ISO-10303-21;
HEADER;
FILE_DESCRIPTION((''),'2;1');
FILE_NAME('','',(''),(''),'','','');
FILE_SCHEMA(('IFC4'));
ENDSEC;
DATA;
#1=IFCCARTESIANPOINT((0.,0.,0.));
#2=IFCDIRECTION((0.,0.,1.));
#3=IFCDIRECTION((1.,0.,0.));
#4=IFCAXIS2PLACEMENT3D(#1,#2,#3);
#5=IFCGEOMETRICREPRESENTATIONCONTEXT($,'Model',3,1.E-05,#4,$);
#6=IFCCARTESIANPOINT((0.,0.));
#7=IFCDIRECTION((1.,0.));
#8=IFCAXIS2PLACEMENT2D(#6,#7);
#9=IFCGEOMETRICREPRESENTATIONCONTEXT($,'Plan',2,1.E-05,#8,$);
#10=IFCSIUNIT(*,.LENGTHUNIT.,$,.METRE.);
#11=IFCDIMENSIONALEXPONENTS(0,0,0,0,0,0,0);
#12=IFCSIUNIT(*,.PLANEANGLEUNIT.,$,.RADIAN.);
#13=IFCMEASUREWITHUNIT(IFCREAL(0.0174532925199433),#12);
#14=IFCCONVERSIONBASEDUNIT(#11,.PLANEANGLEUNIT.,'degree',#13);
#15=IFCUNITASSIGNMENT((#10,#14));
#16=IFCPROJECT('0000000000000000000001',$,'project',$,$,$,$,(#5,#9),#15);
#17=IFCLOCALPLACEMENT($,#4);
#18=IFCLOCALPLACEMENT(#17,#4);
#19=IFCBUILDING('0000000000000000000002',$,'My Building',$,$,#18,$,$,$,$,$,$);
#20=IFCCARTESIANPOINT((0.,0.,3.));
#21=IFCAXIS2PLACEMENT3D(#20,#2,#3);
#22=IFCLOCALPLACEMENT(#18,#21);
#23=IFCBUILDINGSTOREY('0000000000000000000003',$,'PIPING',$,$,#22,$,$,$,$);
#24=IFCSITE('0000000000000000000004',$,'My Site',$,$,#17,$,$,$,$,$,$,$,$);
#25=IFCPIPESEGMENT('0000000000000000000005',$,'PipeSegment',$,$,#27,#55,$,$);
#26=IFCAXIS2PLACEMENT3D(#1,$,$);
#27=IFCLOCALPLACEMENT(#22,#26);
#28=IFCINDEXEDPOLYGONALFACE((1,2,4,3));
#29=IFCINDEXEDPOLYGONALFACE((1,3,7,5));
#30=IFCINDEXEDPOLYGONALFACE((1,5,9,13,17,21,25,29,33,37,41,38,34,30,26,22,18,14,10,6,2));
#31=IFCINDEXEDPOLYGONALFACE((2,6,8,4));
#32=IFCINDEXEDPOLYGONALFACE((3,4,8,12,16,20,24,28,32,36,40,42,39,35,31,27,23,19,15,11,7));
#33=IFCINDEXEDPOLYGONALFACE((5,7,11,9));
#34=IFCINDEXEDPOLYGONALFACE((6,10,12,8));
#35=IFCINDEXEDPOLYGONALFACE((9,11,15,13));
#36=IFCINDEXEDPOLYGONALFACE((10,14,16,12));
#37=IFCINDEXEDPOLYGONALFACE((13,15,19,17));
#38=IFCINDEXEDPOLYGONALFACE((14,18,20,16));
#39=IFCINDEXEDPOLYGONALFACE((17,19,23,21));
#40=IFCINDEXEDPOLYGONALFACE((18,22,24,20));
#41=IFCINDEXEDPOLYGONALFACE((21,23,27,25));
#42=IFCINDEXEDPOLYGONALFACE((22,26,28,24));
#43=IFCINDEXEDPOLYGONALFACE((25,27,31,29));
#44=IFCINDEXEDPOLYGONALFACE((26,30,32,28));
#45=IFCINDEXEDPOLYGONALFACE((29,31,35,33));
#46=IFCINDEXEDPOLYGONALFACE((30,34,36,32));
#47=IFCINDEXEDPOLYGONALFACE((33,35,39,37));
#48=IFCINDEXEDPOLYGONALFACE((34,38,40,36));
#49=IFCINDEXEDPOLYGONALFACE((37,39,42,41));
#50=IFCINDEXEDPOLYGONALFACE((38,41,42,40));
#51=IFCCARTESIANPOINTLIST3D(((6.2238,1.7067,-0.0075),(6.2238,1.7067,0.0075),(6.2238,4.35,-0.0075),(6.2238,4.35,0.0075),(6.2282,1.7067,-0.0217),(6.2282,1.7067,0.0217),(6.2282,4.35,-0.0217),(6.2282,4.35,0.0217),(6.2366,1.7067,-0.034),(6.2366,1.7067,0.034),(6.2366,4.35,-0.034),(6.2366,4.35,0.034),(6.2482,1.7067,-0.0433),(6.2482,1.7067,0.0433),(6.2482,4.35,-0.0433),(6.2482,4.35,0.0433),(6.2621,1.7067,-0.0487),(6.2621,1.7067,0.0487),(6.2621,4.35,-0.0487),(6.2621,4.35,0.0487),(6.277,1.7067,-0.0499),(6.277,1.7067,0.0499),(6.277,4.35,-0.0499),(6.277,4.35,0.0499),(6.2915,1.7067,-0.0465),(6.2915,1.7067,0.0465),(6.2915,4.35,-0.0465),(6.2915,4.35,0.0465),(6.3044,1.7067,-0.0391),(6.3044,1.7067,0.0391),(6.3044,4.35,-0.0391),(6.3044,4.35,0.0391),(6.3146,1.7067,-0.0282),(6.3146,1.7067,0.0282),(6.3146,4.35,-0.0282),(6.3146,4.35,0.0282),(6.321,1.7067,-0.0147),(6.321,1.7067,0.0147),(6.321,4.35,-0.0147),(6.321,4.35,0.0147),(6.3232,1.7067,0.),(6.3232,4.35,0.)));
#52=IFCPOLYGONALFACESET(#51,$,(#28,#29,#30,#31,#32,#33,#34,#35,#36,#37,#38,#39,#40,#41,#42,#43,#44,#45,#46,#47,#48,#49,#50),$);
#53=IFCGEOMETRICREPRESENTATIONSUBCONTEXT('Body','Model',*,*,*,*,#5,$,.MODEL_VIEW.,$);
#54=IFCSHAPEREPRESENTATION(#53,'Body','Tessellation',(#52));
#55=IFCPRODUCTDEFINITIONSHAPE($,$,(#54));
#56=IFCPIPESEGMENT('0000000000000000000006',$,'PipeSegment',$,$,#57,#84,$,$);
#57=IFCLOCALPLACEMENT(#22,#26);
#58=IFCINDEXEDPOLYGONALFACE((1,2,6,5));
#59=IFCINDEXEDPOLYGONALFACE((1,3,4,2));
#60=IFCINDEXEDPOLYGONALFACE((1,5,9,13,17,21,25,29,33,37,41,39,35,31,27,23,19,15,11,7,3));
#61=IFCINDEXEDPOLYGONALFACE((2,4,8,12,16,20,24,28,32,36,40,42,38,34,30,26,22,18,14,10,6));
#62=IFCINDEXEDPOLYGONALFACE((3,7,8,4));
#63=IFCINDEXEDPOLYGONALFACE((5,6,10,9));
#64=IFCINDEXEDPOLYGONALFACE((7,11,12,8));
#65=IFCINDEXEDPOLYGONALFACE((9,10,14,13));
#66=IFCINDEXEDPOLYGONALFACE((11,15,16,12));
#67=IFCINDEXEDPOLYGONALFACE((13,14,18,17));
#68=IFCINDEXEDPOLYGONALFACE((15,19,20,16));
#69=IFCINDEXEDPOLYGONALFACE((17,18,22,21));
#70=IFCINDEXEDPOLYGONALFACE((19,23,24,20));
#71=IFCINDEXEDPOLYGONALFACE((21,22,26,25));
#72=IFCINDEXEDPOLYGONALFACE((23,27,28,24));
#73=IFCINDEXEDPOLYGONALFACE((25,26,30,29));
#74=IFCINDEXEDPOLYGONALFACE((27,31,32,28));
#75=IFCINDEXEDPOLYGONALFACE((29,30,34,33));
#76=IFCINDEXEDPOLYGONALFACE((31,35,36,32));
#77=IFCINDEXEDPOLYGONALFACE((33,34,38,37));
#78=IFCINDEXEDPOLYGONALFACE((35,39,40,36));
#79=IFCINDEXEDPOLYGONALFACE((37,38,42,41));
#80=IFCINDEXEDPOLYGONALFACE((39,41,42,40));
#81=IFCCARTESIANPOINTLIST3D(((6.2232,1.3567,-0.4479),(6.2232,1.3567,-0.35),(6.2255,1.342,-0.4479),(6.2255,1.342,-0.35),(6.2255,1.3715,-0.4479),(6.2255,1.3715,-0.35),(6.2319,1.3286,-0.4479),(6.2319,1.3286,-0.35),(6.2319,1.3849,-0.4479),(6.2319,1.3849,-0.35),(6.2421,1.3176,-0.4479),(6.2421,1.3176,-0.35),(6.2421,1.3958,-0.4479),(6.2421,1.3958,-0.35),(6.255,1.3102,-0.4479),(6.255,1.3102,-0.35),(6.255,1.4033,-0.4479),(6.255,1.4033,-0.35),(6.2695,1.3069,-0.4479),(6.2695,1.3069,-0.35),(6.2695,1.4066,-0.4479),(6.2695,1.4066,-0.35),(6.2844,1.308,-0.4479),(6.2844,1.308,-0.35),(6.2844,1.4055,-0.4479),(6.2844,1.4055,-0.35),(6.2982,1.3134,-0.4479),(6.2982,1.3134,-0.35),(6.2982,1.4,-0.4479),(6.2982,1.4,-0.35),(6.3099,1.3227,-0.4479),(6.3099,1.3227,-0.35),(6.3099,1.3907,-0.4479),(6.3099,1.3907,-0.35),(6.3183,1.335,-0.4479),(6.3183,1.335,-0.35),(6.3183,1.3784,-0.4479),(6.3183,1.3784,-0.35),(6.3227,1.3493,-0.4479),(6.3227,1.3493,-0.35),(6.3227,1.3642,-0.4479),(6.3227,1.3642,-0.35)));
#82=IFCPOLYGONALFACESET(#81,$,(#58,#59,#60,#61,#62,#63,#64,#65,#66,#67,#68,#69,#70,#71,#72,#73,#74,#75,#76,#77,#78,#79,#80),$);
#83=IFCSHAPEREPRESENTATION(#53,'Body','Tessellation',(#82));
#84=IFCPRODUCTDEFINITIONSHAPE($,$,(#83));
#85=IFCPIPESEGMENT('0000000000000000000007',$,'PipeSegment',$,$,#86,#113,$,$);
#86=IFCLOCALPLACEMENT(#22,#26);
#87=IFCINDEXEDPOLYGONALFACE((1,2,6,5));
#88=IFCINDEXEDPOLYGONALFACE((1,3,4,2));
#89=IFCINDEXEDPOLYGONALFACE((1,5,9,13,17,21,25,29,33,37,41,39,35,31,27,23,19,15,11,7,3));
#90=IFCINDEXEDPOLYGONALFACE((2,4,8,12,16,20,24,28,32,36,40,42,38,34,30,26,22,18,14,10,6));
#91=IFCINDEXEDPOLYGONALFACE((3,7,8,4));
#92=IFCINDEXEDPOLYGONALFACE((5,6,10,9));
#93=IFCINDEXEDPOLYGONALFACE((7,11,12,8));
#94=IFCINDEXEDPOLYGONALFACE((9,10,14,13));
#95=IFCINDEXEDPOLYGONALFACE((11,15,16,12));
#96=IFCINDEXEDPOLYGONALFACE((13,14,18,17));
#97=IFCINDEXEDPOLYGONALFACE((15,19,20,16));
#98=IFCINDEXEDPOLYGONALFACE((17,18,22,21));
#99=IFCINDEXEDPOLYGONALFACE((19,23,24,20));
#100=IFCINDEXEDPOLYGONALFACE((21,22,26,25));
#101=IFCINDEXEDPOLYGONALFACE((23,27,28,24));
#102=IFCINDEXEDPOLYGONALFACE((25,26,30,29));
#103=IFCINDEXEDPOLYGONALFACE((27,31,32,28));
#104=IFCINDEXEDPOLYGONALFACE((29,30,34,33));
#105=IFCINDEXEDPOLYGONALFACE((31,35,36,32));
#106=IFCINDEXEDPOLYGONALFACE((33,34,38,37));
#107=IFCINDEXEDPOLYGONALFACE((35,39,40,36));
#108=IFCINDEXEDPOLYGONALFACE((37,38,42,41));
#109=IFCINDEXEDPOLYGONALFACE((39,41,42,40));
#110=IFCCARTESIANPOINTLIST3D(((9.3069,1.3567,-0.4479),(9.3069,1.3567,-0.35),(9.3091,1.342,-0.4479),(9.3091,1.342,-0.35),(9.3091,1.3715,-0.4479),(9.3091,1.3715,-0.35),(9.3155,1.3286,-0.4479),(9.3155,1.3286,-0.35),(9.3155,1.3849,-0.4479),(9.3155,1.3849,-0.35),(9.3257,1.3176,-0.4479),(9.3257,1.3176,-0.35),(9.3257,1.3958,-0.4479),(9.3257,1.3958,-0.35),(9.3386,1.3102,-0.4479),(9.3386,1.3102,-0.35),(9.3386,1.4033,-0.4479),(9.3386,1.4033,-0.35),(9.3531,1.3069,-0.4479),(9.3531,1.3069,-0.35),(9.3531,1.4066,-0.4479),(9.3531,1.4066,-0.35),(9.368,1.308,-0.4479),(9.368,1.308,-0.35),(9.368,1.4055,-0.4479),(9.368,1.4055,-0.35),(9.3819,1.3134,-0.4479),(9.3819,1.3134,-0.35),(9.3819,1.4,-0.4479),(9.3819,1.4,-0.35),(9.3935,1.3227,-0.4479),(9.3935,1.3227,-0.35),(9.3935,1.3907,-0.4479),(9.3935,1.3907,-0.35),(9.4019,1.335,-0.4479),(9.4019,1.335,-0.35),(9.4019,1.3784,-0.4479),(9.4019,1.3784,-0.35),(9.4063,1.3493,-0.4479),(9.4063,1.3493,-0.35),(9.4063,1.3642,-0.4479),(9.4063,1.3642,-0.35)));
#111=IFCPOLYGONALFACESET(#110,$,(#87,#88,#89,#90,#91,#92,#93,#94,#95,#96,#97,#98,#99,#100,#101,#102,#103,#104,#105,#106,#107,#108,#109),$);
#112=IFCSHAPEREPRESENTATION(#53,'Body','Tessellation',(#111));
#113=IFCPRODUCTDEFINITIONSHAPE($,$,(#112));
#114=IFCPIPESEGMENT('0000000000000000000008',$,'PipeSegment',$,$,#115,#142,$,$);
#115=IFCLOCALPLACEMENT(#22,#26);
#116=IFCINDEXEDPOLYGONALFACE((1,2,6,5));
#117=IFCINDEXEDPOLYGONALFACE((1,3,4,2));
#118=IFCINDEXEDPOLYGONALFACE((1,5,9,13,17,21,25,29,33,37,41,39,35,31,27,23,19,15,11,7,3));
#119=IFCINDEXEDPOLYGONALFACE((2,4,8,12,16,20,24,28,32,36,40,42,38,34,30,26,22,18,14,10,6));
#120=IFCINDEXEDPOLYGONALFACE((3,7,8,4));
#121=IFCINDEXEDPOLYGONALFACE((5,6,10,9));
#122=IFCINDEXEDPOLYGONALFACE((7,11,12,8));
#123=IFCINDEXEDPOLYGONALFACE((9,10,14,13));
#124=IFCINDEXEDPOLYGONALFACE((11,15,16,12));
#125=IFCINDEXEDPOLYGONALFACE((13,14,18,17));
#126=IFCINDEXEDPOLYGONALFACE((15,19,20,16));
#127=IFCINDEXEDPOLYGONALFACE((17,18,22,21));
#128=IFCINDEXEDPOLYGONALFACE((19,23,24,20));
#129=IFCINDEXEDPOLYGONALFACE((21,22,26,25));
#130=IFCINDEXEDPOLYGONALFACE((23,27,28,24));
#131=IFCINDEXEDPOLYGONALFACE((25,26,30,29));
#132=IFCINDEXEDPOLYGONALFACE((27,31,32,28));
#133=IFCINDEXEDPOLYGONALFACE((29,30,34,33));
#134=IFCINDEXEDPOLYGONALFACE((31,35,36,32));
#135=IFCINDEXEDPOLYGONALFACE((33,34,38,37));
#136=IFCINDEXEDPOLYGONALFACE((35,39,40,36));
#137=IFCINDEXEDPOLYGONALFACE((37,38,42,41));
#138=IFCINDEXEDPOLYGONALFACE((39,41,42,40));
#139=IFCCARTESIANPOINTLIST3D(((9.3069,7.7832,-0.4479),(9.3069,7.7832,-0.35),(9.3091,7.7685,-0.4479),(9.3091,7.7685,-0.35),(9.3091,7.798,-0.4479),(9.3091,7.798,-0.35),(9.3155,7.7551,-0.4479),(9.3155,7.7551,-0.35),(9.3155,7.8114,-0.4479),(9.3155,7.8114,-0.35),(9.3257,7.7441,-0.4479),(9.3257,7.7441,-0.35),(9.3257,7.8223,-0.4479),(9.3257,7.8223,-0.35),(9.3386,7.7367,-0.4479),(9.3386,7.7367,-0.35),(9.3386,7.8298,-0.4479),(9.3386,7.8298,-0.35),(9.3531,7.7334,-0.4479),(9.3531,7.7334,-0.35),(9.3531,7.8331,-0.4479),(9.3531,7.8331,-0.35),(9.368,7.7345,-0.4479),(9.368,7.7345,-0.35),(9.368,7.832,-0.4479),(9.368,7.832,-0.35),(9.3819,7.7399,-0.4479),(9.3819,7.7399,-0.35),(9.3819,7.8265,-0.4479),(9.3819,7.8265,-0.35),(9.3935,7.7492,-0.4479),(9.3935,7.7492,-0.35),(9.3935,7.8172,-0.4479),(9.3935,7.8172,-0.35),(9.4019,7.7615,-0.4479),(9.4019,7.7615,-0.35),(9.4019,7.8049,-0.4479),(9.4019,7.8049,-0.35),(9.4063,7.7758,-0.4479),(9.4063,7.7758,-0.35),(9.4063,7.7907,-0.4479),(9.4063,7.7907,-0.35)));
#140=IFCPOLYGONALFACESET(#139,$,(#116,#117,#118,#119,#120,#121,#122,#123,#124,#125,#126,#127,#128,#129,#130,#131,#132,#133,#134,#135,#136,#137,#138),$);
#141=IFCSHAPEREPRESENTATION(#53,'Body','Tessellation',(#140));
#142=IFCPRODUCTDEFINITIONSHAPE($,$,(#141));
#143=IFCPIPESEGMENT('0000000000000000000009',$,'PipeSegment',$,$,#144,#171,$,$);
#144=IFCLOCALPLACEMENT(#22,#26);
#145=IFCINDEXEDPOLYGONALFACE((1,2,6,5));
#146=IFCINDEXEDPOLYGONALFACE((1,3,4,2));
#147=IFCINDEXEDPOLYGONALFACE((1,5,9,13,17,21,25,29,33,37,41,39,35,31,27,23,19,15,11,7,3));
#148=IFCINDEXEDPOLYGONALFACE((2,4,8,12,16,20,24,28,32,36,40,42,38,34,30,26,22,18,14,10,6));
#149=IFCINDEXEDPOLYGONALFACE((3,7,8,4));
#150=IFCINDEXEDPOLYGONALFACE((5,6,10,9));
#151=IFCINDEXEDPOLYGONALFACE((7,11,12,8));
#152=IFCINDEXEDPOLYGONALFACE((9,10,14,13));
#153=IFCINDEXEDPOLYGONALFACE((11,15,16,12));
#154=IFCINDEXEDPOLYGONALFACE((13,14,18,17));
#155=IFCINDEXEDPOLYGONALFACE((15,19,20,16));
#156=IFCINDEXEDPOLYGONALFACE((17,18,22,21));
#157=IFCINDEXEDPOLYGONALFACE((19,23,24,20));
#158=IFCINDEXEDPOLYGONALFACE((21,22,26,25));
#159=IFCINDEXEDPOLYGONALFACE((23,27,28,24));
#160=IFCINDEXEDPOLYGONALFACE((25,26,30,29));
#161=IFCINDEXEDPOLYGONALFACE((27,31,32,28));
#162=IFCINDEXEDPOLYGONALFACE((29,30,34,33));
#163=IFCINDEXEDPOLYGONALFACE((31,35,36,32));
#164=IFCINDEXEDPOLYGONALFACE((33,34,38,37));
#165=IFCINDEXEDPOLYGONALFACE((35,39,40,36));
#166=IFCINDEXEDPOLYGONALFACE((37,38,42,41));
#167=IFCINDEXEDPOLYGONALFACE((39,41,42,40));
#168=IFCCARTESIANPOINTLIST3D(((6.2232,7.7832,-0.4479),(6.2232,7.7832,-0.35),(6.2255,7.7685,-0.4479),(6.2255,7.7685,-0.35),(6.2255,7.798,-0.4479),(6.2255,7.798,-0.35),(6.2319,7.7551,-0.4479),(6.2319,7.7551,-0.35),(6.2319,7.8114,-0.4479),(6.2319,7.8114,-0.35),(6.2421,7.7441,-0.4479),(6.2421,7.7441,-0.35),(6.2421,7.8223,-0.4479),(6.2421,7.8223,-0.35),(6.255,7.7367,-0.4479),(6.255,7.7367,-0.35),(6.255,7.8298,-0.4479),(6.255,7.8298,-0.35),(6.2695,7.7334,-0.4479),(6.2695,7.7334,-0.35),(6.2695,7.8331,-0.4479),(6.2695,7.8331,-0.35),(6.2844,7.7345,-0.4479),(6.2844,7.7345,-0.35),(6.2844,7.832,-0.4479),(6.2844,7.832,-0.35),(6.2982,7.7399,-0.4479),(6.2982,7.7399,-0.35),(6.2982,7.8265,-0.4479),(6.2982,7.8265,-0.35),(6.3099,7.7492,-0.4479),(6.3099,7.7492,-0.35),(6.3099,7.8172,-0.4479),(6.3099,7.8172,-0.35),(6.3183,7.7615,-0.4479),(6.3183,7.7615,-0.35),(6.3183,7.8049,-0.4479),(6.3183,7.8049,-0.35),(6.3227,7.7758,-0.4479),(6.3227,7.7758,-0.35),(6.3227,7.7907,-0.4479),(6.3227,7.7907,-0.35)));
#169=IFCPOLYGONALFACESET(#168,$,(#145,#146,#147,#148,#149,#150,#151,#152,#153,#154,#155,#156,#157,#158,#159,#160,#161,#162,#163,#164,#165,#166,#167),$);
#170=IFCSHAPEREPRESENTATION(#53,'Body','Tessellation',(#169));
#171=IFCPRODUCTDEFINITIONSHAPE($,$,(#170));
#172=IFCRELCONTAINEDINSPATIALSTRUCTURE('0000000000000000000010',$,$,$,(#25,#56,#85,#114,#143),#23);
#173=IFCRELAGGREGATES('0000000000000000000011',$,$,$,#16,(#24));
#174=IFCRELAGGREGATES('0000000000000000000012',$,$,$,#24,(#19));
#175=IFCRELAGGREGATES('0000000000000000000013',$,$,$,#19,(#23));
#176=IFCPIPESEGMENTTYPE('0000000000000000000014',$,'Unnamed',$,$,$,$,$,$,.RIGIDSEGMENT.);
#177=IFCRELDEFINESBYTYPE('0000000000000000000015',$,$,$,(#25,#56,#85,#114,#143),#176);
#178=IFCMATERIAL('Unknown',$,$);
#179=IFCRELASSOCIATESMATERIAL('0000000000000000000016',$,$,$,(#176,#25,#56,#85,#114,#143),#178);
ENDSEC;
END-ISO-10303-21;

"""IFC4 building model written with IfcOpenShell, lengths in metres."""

from ifc_helpers import new_model, entity, si_unit, converted_unit, frame, origin_with_axes, origin_2d_with_axis, place, context, subcontext, project, spatial, circle, extrude, material, material_profile, profile_set, profile_usage, type_object, element, save


model = new_model("IFC4")

# Units and contexts
model_context = context("Model", 3, precision=1e-05, world=origin_with_axes())
plan_context = context("Plan", 2, precision=1e-05, world=origin_2d_with_axis())
body_context = subcontext(model_context, "Body", "Model", "MODEL_VIEW")
ifc_project = project(units=[si_unit("LENGTHUNIT", "METRE"), converted_unit("PLANEANGLEUNIT", "degree", entity("IfcReal", 0.0174532925199433), si_unit("PLANEANGLEUNIT", "RADIAN"), dimensions=[0, 0, 0, 0, 0, 0, 0])], contexts=[model_context, plan_context])

# Site, building, storey
site_placement = place(None, origin_with_axes())
site = spatial("IfcSite", under=ifc_project, at=site_placement, Name="My Site")
building_placement = place(site_placement, origin_with_axes())
building = spatial("IfcBuilding", under=site, at=building_placement, Name="My Building")
storey_placement = place(building_placement, frame((0.0, 0.0, 3.0), z_axis=(0.0, 0.0, 1.0), x_axis=(1.0, 0.0, 0.0)))
storey = spatial("IfcBuildingStorey", under=building, at=storey_placement, Name="PIPING")

# Pipe segments
ifc_material = material(Name="Unknown")
ifc_material_profile_1 = material_profile(ifc_material, circle(Radius=0.05))
ifc_profile_set_1 = profile_set([ifc_material_profile_1])
pipe_segment_type = type_object("IfcPipeSegmentType", Name="Unnamed", PredefinedType="RIGIDSEGMENT", material=ifc_profile_set_1)
ifc_profile_usage_1 = profile_usage(ifc_profile_set_1, cardinal=5)
pipe_segment_1_placement = place(storey_placement, frame((6.2732, 4.35, 0.0), z_axis=(0.0, -1.0, 0.0), x_axis=(1.0, 0.0, 0.0)))
element("IfcPipeSegment", 1, at=pipe_segment_1_placement, inside=storey, type_object=pipe_segment_type, material=ifc_profile_usage_1, Name="PipeSegment", context=body_context, shape_type="SweptSolid", body=[
    extrude(circle(Radius=0.05), origin_with_axes(), (0.0, 0.0, 1.0), 2.6433),
])
ifc_profile_usage_2 = profile_usage(ifc_profile_set_1, cardinal=5)
pipe_segment_2_placement = place(storey_placement, frame((6.2732, 1.3567, -0.35), z_axis=(0.0, 0.0, -1.0), x_axis=(-1.0, 0.0, 0.0)))
element("IfcPipeSegment", 2, at=pipe_segment_2_placement, inside=storey, type_object=pipe_segment_type, material=ifc_profile_usage_2, Name="PipeSegment", context=body_context, shape_type="SweptSolid", body=[
    extrude(circle(Radius=0.05), origin_with_axes(), (0.0, 0.0, 1.0), 0.0979),
])
ifc_profile_usage_3 = profile_usage(ifc_profile_set_1, cardinal=5)
pipe_segment_3_placement = place(storey_placement, frame((9.3569, 1.3567, -0.35), z_axis=(0.0, 0.0, -1.0), x_axis=(-1.0, 0.0, 0.0)))
element("IfcPipeSegment", 3, at=pipe_segment_3_placement, inside=storey, type_object=pipe_segment_type, material=ifc_profile_usage_3, Name="PipeSegment", context=body_context, shape_type="SweptSolid", body=[
    extrude(circle(Radius=0.05), origin_with_axes(), (0.0, 0.0, 1.0), 0.0979),
])
ifc_profile_usage_4 = profile_usage(ifc_profile_set_1, cardinal=5)
pipe_segment_4_placement = place(storey_placement, frame((9.3569, 7.7832, -0.35), z_axis=(0.0, 0.0, -1.0), x_axis=(-1.0, 0.0, 0.0)))
element("IfcPipeSegment", 4, at=pipe_segment_4_placement, inside=storey, type_object=pipe_segment_type, material=ifc_profile_usage_4, Name="PipeSegment", context=body_context, shape_type="SweptSolid", body=[
    extrude(circle(Radius=0.05), origin_with_axes(), (0.0, 0.0, 1.0), 0.0979),
])
ifc_profile_usage_5 = profile_usage(ifc_profile_set_1, cardinal=5)
pipe_segment_5_placement = place(storey_placement, frame((6.2732, 7.7832, -0.35), z_axis=(0.0, 0.0, -1.0), x_axis=(-1.0, 0.0, 0.0)))
element("IfcPipeSegment", 5, at=pipe_segment_5_placement, inside=storey, type_object=pipe_segment_type, material=ifc_profile_usage_5, Name="PipeSegment", context=body_context, shape_type="SweptSolid", body=[
    extrude(circle(Radius=0.05), origin_with_axes(), (0.0, 0.0, 1.0), 0.0979),
])

save(model, "model.ifc")
